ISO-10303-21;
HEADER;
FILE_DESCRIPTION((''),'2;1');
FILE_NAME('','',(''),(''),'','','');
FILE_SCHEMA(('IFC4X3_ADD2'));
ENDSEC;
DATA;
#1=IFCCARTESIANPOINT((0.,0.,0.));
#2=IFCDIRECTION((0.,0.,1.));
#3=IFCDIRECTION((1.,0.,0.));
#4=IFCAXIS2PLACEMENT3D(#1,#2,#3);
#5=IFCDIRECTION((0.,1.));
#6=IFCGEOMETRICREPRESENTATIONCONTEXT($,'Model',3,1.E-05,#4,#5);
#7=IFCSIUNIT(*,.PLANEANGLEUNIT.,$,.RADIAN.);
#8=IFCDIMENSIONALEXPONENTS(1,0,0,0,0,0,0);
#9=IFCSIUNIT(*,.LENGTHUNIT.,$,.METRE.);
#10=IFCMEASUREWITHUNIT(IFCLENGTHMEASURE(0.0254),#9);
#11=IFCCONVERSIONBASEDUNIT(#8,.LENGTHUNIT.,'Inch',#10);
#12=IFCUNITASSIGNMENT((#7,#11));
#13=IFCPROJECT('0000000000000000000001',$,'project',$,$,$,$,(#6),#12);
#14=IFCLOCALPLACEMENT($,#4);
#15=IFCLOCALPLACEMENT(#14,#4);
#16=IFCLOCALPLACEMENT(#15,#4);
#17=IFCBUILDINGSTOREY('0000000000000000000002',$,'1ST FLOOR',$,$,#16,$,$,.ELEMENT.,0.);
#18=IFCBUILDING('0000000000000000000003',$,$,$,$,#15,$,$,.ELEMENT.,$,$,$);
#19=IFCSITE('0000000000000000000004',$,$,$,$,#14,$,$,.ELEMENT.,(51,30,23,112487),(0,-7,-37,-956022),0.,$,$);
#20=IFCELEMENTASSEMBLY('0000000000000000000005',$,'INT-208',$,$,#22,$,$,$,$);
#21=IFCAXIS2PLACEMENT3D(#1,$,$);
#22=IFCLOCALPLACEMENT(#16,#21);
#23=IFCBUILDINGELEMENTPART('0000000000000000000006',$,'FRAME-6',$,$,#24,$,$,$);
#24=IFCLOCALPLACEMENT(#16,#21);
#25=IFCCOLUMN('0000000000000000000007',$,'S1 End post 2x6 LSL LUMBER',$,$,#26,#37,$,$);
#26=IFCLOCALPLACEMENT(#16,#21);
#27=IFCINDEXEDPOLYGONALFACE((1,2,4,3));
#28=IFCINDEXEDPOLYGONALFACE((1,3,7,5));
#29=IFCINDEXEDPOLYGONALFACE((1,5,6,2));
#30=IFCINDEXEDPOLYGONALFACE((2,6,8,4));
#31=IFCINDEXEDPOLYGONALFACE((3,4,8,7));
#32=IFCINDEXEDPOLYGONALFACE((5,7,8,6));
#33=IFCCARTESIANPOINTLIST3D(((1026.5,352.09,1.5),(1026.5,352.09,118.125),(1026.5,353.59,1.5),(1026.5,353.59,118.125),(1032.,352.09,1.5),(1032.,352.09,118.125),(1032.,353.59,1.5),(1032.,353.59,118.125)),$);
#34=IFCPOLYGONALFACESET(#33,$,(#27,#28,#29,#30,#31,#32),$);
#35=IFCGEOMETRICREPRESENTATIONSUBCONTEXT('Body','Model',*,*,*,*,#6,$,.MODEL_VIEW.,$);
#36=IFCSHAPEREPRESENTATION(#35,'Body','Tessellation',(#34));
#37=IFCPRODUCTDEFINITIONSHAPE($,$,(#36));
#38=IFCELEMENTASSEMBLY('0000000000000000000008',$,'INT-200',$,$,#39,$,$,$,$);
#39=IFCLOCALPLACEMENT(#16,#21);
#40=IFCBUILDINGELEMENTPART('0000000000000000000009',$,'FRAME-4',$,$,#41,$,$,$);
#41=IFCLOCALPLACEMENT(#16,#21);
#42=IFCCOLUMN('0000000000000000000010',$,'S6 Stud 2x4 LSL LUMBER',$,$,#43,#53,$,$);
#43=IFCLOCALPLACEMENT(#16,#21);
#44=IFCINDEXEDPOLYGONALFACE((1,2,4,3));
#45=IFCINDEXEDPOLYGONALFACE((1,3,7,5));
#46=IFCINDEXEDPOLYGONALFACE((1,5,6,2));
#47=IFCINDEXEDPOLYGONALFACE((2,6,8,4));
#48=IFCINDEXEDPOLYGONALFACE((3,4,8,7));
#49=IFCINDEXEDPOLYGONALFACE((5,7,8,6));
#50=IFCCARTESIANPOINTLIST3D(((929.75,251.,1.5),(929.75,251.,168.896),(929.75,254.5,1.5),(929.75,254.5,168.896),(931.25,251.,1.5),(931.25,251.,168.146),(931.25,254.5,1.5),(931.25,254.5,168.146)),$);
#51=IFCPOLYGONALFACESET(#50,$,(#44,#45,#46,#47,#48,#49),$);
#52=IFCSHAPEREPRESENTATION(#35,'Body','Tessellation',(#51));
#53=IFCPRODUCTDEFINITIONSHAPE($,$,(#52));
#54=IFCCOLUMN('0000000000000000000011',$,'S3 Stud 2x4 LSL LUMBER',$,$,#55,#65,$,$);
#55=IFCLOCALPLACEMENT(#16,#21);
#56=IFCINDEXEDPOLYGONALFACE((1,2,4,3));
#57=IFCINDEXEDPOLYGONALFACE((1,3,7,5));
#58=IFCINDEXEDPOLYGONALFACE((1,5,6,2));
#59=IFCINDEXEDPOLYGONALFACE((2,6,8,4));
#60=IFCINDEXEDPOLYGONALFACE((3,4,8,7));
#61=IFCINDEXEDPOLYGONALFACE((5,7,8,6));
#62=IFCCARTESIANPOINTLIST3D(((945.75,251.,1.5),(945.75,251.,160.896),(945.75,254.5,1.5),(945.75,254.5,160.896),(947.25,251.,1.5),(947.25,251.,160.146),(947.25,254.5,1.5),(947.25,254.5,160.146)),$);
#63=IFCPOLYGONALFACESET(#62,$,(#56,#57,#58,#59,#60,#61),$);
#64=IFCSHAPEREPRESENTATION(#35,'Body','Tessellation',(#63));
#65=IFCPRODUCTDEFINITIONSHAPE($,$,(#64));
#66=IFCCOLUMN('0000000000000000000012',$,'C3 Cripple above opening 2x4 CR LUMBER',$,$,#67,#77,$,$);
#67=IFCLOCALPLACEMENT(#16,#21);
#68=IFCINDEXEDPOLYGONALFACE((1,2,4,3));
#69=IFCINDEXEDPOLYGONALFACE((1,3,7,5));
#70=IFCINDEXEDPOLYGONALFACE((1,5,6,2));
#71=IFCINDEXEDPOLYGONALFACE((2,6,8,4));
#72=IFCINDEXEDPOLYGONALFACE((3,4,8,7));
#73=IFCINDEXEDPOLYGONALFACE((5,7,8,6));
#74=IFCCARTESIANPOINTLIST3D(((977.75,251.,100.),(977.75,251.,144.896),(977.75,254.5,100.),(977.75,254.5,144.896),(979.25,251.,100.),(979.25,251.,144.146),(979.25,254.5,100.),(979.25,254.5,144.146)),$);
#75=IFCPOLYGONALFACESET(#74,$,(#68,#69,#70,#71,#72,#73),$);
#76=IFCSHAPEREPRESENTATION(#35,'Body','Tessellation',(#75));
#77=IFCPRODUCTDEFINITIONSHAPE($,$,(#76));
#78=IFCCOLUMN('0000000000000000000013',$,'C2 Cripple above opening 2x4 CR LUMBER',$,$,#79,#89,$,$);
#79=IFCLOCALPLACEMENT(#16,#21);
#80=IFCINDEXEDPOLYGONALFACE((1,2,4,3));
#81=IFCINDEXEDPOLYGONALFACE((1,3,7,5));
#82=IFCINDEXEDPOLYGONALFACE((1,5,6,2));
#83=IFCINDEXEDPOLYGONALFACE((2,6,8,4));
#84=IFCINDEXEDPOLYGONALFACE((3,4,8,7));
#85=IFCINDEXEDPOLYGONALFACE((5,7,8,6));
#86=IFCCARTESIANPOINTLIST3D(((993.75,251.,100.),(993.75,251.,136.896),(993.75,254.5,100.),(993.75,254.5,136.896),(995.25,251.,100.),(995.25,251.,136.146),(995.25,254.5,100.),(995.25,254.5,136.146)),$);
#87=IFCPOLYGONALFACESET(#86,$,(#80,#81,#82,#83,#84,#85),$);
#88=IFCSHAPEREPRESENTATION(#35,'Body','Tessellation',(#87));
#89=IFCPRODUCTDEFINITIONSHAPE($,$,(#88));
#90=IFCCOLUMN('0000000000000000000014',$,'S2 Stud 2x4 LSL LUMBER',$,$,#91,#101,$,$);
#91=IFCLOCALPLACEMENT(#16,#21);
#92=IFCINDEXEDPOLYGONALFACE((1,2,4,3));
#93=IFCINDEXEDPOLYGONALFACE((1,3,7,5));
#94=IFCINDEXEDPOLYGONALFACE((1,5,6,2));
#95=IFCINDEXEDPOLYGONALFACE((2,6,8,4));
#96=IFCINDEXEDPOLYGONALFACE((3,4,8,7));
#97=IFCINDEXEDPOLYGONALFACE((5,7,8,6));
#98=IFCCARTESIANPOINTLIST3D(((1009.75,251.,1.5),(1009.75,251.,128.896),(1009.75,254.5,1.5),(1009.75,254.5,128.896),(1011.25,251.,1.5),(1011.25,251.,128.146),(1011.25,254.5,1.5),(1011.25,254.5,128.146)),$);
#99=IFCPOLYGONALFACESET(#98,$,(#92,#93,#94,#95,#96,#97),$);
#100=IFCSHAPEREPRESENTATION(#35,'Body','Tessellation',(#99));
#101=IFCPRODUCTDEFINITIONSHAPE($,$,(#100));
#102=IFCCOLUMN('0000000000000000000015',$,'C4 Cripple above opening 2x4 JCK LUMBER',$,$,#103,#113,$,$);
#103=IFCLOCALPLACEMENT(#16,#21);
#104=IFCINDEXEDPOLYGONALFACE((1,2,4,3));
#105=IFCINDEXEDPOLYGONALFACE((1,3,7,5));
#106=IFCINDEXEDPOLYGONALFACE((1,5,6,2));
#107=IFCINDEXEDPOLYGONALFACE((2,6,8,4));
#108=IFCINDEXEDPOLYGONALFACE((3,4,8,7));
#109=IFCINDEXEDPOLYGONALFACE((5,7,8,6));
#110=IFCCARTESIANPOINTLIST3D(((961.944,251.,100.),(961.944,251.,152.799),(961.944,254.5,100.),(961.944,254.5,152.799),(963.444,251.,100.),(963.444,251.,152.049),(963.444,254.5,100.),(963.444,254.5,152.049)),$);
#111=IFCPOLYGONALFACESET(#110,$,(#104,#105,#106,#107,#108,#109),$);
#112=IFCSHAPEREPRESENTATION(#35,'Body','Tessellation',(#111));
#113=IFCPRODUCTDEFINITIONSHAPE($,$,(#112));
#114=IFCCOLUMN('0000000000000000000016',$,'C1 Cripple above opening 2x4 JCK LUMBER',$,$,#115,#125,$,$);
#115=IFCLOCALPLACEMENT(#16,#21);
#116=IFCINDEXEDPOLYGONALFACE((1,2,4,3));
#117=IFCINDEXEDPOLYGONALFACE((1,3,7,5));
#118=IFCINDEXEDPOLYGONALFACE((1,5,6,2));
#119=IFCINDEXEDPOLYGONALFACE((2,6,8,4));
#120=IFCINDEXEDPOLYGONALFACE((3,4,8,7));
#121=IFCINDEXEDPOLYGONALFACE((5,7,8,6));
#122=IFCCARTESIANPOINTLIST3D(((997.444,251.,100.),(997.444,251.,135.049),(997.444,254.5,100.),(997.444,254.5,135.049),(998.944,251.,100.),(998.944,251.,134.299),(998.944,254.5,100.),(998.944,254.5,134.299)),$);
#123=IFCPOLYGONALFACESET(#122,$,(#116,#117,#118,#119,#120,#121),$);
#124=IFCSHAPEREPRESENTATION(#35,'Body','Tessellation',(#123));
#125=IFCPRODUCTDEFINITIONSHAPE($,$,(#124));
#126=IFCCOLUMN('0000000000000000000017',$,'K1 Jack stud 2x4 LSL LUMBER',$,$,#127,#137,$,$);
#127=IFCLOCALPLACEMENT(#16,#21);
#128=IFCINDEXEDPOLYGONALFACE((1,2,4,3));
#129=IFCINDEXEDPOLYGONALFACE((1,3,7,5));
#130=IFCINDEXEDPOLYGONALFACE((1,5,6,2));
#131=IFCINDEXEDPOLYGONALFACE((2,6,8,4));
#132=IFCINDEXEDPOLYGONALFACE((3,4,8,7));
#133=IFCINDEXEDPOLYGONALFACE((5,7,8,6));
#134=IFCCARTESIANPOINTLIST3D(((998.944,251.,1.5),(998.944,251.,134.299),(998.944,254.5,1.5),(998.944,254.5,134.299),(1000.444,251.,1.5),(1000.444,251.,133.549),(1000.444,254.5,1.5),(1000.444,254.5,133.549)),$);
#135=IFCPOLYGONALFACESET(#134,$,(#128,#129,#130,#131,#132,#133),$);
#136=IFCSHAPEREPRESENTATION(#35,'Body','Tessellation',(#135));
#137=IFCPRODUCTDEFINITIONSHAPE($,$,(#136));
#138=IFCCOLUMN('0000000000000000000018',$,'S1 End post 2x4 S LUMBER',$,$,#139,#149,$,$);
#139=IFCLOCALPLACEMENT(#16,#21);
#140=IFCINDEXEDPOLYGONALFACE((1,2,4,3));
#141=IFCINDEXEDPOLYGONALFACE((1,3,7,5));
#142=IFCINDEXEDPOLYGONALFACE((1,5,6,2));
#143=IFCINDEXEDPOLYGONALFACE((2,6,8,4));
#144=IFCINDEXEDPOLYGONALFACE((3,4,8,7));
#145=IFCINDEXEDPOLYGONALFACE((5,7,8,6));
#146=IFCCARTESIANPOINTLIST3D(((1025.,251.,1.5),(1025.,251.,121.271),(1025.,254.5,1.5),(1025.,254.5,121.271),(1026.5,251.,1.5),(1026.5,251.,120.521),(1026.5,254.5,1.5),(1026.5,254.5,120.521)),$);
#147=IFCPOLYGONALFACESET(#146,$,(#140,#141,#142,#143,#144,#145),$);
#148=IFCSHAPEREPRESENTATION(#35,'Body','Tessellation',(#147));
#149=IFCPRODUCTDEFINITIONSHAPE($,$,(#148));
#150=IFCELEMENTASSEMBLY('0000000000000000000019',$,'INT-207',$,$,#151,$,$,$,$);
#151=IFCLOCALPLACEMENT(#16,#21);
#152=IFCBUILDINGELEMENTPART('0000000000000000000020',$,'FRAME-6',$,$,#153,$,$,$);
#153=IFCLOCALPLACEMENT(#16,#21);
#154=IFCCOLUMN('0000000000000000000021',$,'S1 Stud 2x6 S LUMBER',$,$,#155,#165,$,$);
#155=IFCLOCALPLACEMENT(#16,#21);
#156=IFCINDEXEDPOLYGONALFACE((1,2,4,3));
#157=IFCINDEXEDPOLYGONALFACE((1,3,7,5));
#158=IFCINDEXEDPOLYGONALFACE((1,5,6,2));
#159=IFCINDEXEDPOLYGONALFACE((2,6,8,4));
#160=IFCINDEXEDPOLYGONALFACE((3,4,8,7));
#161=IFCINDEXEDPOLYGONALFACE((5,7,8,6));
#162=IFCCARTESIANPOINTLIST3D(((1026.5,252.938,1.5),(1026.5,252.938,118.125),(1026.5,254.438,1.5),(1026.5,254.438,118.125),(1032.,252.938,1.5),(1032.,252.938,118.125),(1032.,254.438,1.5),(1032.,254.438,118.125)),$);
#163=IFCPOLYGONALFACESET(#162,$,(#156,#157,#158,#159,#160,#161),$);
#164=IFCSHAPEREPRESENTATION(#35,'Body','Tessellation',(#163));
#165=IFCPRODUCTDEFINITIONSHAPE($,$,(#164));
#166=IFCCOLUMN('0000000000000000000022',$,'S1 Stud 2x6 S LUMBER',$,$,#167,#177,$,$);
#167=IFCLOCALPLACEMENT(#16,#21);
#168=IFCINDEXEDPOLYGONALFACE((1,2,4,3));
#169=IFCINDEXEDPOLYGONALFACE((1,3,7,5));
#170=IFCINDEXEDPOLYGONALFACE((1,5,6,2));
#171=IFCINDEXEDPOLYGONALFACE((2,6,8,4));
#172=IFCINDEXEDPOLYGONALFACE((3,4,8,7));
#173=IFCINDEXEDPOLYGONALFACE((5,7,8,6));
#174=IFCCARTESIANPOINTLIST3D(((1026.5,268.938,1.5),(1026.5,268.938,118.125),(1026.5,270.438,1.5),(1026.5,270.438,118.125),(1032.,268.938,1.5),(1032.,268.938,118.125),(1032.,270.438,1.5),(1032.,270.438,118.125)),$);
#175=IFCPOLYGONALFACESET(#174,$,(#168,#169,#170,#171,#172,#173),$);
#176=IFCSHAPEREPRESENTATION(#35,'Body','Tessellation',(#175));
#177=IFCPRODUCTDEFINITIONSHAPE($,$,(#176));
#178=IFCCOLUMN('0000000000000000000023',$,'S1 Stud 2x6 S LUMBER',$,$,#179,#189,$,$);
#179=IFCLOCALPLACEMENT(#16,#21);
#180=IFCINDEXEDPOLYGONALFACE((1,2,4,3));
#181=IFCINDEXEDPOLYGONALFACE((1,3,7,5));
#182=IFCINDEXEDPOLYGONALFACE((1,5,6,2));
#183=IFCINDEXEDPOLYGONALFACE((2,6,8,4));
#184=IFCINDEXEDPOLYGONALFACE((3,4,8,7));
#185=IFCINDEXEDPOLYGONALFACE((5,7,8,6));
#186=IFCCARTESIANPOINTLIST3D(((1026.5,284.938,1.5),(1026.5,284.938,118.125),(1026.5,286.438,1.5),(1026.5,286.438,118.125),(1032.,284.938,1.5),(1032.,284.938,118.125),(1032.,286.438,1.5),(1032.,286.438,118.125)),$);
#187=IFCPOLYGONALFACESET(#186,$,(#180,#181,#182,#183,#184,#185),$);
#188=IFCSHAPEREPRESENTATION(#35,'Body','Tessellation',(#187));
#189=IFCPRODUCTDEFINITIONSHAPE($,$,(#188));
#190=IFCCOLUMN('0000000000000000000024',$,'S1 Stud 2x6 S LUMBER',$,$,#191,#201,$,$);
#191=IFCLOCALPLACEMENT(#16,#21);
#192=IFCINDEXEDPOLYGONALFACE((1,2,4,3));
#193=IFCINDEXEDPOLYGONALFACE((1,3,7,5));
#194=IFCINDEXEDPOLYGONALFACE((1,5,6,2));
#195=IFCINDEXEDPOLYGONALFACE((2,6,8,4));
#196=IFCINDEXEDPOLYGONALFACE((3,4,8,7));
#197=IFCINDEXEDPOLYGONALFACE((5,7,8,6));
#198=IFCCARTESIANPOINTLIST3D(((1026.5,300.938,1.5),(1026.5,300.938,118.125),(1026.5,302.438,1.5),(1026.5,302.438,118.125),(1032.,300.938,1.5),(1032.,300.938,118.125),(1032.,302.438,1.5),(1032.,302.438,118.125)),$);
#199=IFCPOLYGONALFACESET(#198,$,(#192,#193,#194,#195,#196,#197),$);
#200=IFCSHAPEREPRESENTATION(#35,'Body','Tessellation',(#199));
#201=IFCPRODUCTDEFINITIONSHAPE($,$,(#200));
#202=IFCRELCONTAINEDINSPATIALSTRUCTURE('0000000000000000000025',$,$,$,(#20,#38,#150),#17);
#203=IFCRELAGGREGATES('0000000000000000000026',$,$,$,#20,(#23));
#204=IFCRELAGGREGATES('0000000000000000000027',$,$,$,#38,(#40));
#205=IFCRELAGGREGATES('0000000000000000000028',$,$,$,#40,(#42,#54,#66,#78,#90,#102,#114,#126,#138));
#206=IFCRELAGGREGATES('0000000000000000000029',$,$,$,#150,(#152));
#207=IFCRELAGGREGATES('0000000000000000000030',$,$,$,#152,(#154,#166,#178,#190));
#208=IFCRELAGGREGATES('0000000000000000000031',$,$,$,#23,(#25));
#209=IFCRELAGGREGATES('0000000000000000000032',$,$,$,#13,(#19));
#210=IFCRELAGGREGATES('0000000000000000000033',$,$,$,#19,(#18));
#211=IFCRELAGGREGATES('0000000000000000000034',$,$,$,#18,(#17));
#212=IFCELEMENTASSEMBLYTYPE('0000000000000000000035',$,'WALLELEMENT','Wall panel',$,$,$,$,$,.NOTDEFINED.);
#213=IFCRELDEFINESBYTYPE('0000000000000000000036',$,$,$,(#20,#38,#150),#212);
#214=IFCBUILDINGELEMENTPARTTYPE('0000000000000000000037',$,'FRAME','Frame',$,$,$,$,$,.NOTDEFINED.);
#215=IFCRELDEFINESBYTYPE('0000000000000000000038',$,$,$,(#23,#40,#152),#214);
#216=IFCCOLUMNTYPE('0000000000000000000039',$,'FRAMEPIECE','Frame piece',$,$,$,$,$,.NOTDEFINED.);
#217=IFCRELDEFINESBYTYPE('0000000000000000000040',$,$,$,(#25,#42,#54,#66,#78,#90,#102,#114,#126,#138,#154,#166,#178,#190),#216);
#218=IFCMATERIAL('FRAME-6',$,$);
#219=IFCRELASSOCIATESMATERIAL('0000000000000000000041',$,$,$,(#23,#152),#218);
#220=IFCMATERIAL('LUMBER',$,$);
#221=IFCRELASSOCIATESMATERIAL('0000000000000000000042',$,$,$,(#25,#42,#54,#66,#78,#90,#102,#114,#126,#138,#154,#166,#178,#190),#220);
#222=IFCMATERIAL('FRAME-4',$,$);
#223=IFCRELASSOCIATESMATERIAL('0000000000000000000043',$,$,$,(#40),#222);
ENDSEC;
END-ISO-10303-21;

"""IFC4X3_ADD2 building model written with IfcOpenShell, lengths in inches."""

from ifc_helpers import new_model, entity, si_unit, converted_unit, direction, frame, origin_with_axes, origin_2d_with_axis, place, context, subcontext, project, spatial, rectangle, extrude, clip, halfspace, material, type_object, element, aggregate, save


model = new_model("IFC4X3_ADD2")

# Units and contexts
model_context = context("Model", 3, precision=1e-05, world=origin_with_axes(), true_north=direction((0.0, 1.0)))
body_context = subcontext(model_context, "Body", "Model", "MODEL_VIEW")
ifc_project = project(units=[si_unit("PLANEANGLEUNIT", "RADIAN"), converted_unit("LENGTHUNIT", "Inch", entity("IfcLengthMeasure", 0.0254), si_unit("LENGTHUNIT", "METRE"), dimensions=[1, 0, 0, 0, 0, 0, 0])], contexts=[model_context])

# Site, building, storey
site_placement = place(None, origin_with_axes())
site = spatial("IfcSite", under=ifc_project, at=site_placement, CompositionType="ELEMENT", RefLatitude=(51, 30, 23, 112487), RefLongitude=(0, -7, -37, -956022), RefElevation=0.0)
building_placement = place(site_placement, origin_with_axes())
building = spatial("IfcBuilding", under=site, at=building_placement, CompositionType="ELEMENT")
storey_placement = place(building_placement, origin_with_axes())
storey = spatial("IfcBuildingStorey", under=building, at=storey_placement, Name="1ST FLOOR", CompositionType="ELEMENT", Elevation=0.0)

# Element assembly, building element part, column
element_assembly_type = type_object("IfcElementAssemblyType", Name="WALLELEMENT", Description="Wall panel", PredefinedType="NOTDEFINED")
assembly_1_placement = place(storey_placement, origin_with_axes())
assembly_1 = element("IfcElementAssembly", 1, at=assembly_1_placement, inside=storey, type_object=element_assembly_type, Name="INT-208")
ifc_material_1 = material(Name="FRAME-6")
building_element_part_type = type_object("IfcBuildingElementPartType", Name="FRAME", Description="Frame", PredefinedType="NOTDEFINED")
building_element_part_1_placement = place(storey_placement, origin_with_axes())
building_element_part_1 = element("IfcBuildingElementPart", 2, at=building_element_part_1_placement, type_object=building_element_part_type, material=ifc_material_1, Name="FRAME-6")
aggregate(assembly_1, [building_element_part_1])
ifc_material_2 = material(Name="LUMBER")
column_type = type_object("IfcColumnType", Name="FRAMEPIECE", Description="Frame piece", PredefinedType="NOTDEFINED")
column_1_placement = place(storey_placement, frame((1029.25, 352.84, 118.125), z_axis=(0.0, 0.0, -1.0), x_axis=(0.0, -1.0, 0.0)))
column_1 = element("IfcColumn", 3, at=column_1_placement, type_object=column_type, material=ifc_material_2, Name="S1 End post 2x6 LSL LUMBER", context=body_context, shape_type="SweptSolid", body=[
    extrude(rectangle(XDim=1.5, YDim=5.5, at=origin_2d_with_axis()), origin_with_axes(), (0.0, 0.0, 1.0), 116.625),
])

# Element assemblies, building element parts, columns
assembly_2_placement = place(storey_placement, origin_with_axes())
assembly_2 = element("IfcElementAssembly", 4, at=assembly_2_placement, inside=storey, type_object=element_assembly_type, Name="INT-200")
ifc_material_3 = material(Name="FRAME-4")
building_element_part_2_placement = place(storey_placement, origin_with_axes())
building_element_part_2 = element("IfcBuildingElementPart", 5, at=building_element_part_2_placement, type_object=building_element_part_type, material=ifc_material_3, Name="FRAME-4")
aggregate(assembly_2, [building_element_part_2])
column_2_placement = place(storey_placement, frame((930.5, 252.75, 168.896), z_axis=(0.0, 0.0, -1.0), x_axis=(-1.0, 0.0, 0.0)))
column_2 = element("IfcColumn", 6, at=column_2_placement, type_object=column_type, material=ifc_material_2, Name="S6 Stud 2x4 LSL LUMBER", context=body_context, shape_type="CSG", body=[
    clip(extrude(rectangle(XDim=1.5, YDim=3.5, at=origin_2d_with_axis()), origin_with_axes(), (0.0, 0.0, 1.0), 167.396), halfspace(frame((0.0, 0.0, 0.375), z_axis=(-0.447214, 0.0, -0.894427), x_axis=(-0.894427, 0.0, 0.447214)), False)),
])
column_3_placement = place(storey_placement, frame((946.5, 252.75, 160.896), z_axis=(0.0, 0.0, -1.0), x_axis=(-1.0, 0.0, 0.0)))
column_3 = element("IfcColumn", 7, at=column_3_placement, type_object=column_type, material=ifc_material_2, Name="S3 Stud 2x4 LSL LUMBER", context=body_context, shape_type="CSG", body=[
    clip(extrude(rectangle(XDim=1.5, YDim=3.5, at=origin_2d_with_axis()), origin_with_axes(), (0.0, 0.0, 1.0), 159.396), halfspace(frame((0.0, 0.0, 0.375), z_axis=(-0.447214, 0.0, -0.894427), x_axis=(-0.894427, 0.0, 0.447214)), False)),
])
column_4_placement = place(storey_placement, frame((978.5, 252.75, 144.896), z_axis=(0.0, 0.0, -1.0), x_axis=(-1.0, 0.0, 0.0)))
column_4 = element("IfcColumn", 8, at=column_4_placement, type_object=column_type, material=ifc_material_2, Name="C3 Cripple above opening 2x4 CR LUMBER", context=body_context, shape_type="CSG", body=[
    clip(extrude(rectangle(XDim=1.5, YDim=3.5, at=origin_2d_with_axis()), origin_with_axes(), (0.0, 0.0, 1.0), 44.896), halfspace(frame((0.0, 0.0, 0.375), z_axis=(-0.447214, 0.0, -0.894427), x_axis=(-0.894427, 0.0, 0.447214)), False)),
])
column_5_placement = place(storey_placement, frame((994.5, 252.75, 136.896), z_axis=(0.0, 0.0, -1.0), x_axis=(-1.0, 0.0, 0.0)))
column_5 = element("IfcColumn", 9, at=column_5_placement, type_object=column_type, material=ifc_material_2, Name="C2 Cripple above opening 2x4 CR LUMBER", context=body_context, shape_type="CSG", body=[
    clip(extrude(rectangle(XDim=1.5, YDim=3.5, at=origin_2d_with_axis()), origin_with_axes(), (0.0, 0.0, 1.0), 36.896), halfspace(frame((0.0, 0.0, 0.375), z_axis=(-0.447214, 0.0, -0.894427), x_axis=(-0.894427, 0.0, 0.447214)), False)),
])
column_6_placement = place(storey_placement, frame((1010.5, 252.75, 128.896), z_axis=(0.0, 0.0, -1.0), x_axis=(-1.0, 0.0, 0.0)))
column_6 = element("IfcColumn", 10, at=column_6_placement, type_object=column_type, material=ifc_material_2, Name="S2 Stud 2x4 LSL LUMBER", context=body_context, shape_type="CSG", body=[
    clip(extrude(rectangle(XDim=1.5, YDim=3.5, at=origin_2d_with_axis()), origin_with_axes(), (0.0, 0.0, 1.0), 127.396), halfspace(frame((0.0, 0.0, 0.375), z_axis=(-0.447214, 0.0, -0.894427), x_axis=(-0.894427, 0.0, 0.447214)), False)),
])
column_7_placement = place(storey_placement, frame((962.694, 252.75, 100.0), z_axis=(0.0, 0.0, 1.0), x_axis=(1.0, 0.0, 0.0)))
column_7 = element("IfcColumn", 11, at=column_7_placement, type_object=column_type, material=ifc_material_2, Name="C4 Cripple above opening 2x4 JCK LUMBER", context=body_context, shape_type="CSG", body=[
    clip(extrude(rectangle(XDim=1.5, YDim=3.5, at=origin_2d_with_axis()), origin_with_axes(), (0.0, 0.0, 1.0), 52.799), halfspace(frame((0.0, 0.0, 52.424), z_axis=(0.447214, 0.0, 0.894427), x_axis=(0.894427, 0.0, -0.447214)), False)),
])
column_8_placement = place(storey_placement, frame((998.194, 252.75, 135.049), z_axis=(0.0, 0.0, -1.0), x_axis=(-1.0, 0.0, 0.0)))
column_8 = element("IfcColumn", 12, at=column_8_placement, type_object=column_type, material=ifc_material_2, Name="C1 Cripple above opening 2x4 JCK LUMBER", context=body_context, shape_type="CSG", body=[
    clip(extrude(rectangle(XDim=1.5, YDim=3.5, at=origin_2d_with_axis()), origin_with_axes(), (0.0, 0.0, 1.0), 35.049), halfspace(frame((0.0, 0.0, 0.375), z_axis=(-0.447214, 0.0, -0.894427), x_axis=(-0.894427, 0.0, 0.447214)), False)),
])
column_9_placement = place(storey_placement, frame((999.694, 252.75, 134.299), z_axis=(0.0, 0.0, -1.0), x_axis=(-1.0, 0.0, 0.0)))
column_9 = element("IfcColumn", 13, at=column_9_placement, type_object=column_type, material=ifc_material_2, Name="K1 Jack stud 2x4 LSL LUMBER", context=body_context, shape_type="CSG", body=[
    clip(extrude(rectangle(XDim=1.5, YDim=3.5, at=origin_2d_with_axis()), origin_with_axes(), (0.0, 0.0, 1.0), 132.799), halfspace(frame((0.0, 0.0, 0.375), z_axis=(-0.447214, 0.0, -0.894427), x_axis=(-0.894427, 0.0, 0.447214)), False)),
])
column_10_placement = place(storey_placement, frame((1025.75, 252.75, 121.271), z_axis=(0.0, 0.0, -1.0), x_axis=(-1.0, 0.0, 0.0)))
column_10 = element("IfcColumn", 14, at=column_10_placement, type_object=column_type, material=ifc_material_2, Name="S1 End post 2x4 S LUMBER", context=body_context, shape_type="CSG", body=[
    clip(extrude(rectangle(XDim=1.5, YDim=3.5, at=origin_2d_with_axis()), origin_with_axes(), (0.0, 0.0, 1.0), 119.771), halfspace(frame((0.0, 0.0, 0.375), z_axis=(-0.447214, 0.0, -0.894427), x_axis=(-0.894427, 0.0, 0.447214)), False)),
])
aggregate(building_element_part_2, [column_2, column_3, column_4, column_5, column_6, column_7, column_8, column_9, column_10])
assembly_3_placement = place(storey_placement, origin_with_axes())
assembly_3 = element("IfcElementAssembly", 15, at=assembly_3_placement, inside=storey, type_object=element_assembly_type, Name="INT-207")
building_element_part_3_placement = place(storey_placement, origin_with_axes())
building_element_part_3 = element("IfcBuildingElementPart", 16, at=building_element_part_3_placement, type_object=building_element_part_type, material=ifc_material_1, Name="FRAME-6")
aggregate(assembly_3, [building_element_part_3])
column_11_placement = place(storey_placement, frame((1029.25, 253.688, 118.125), z_axis=(0.0, 0.0, -1.0), x_axis=(0.0, -1.0, 0.0)))
column_11 = element("IfcColumn", 17, at=column_11_placement, type_object=column_type, material=ifc_material_2, Name="S1 Stud 2x6 S LUMBER", context=body_context, shape_type="SweptSolid", body=[
    extrude(rectangle(XDim=1.5, YDim=5.5, at=origin_2d_with_axis()), origin_with_axes(), (0.0, 0.0, 1.0), 116.625),
])
column_12_placement = place(storey_placement, frame((1029.25, 269.688, 118.125), z_axis=(0.0, 0.0, -1.0), x_axis=(0.0, -1.0, 0.0)))
column_12 = element("IfcColumn", 18, at=column_12_placement, type_object=column_type, material=ifc_material_2, Name="S1 Stud 2x6 S LUMBER", context=body_context, shape_type="SweptSolid", body=[
    extrude(rectangle(XDim=1.5, YDim=5.5, at=origin_2d_with_axis()), origin_with_axes(), (0.0, 0.0, 1.0), 116.625),
])
column_13_placement = place(storey_placement, frame((1029.25, 285.688, 118.125), z_axis=(0.0, 0.0, -1.0), x_axis=(0.0, -1.0, 0.0)))
column_13 = element("IfcColumn", 19, at=column_13_placement, type_object=column_type, material=ifc_material_2, Name="S1 Stud 2x6 S LUMBER", context=body_context, shape_type="SweptSolid", body=[
    extrude(rectangle(XDim=1.5, YDim=5.5, at=origin_2d_with_axis()), origin_with_axes(), (0.0, 0.0, 1.0), 116.625),
])
column_14_placement = place(storey_placement, frame((1029.25, 301.688, 118.125), z_axis=(0.0, 0.0, -1.0), x_axis=(0.0, -1.0, 0.0)))
column_14 = element("IfcColumn", 20, at=column_14_placement, type_object=column_type, material=ifc_material_2, Name="S1 Stud 2x6 S LUMBER", context=body_context, shape_type="SweptSolid", body=[
    extrude(rectangle(XDim=1.5, YDim=5.5, at=origin_2d_with_axis()), origin_with_axes(), (0.0, 0.0, 1.0), 116.625),
])
aggregate(building_element_part_3, [column_11, column_12, column_13, column_14])

aggregate(building_element_part_1, [column_1])

save(model, "model.ifc")
